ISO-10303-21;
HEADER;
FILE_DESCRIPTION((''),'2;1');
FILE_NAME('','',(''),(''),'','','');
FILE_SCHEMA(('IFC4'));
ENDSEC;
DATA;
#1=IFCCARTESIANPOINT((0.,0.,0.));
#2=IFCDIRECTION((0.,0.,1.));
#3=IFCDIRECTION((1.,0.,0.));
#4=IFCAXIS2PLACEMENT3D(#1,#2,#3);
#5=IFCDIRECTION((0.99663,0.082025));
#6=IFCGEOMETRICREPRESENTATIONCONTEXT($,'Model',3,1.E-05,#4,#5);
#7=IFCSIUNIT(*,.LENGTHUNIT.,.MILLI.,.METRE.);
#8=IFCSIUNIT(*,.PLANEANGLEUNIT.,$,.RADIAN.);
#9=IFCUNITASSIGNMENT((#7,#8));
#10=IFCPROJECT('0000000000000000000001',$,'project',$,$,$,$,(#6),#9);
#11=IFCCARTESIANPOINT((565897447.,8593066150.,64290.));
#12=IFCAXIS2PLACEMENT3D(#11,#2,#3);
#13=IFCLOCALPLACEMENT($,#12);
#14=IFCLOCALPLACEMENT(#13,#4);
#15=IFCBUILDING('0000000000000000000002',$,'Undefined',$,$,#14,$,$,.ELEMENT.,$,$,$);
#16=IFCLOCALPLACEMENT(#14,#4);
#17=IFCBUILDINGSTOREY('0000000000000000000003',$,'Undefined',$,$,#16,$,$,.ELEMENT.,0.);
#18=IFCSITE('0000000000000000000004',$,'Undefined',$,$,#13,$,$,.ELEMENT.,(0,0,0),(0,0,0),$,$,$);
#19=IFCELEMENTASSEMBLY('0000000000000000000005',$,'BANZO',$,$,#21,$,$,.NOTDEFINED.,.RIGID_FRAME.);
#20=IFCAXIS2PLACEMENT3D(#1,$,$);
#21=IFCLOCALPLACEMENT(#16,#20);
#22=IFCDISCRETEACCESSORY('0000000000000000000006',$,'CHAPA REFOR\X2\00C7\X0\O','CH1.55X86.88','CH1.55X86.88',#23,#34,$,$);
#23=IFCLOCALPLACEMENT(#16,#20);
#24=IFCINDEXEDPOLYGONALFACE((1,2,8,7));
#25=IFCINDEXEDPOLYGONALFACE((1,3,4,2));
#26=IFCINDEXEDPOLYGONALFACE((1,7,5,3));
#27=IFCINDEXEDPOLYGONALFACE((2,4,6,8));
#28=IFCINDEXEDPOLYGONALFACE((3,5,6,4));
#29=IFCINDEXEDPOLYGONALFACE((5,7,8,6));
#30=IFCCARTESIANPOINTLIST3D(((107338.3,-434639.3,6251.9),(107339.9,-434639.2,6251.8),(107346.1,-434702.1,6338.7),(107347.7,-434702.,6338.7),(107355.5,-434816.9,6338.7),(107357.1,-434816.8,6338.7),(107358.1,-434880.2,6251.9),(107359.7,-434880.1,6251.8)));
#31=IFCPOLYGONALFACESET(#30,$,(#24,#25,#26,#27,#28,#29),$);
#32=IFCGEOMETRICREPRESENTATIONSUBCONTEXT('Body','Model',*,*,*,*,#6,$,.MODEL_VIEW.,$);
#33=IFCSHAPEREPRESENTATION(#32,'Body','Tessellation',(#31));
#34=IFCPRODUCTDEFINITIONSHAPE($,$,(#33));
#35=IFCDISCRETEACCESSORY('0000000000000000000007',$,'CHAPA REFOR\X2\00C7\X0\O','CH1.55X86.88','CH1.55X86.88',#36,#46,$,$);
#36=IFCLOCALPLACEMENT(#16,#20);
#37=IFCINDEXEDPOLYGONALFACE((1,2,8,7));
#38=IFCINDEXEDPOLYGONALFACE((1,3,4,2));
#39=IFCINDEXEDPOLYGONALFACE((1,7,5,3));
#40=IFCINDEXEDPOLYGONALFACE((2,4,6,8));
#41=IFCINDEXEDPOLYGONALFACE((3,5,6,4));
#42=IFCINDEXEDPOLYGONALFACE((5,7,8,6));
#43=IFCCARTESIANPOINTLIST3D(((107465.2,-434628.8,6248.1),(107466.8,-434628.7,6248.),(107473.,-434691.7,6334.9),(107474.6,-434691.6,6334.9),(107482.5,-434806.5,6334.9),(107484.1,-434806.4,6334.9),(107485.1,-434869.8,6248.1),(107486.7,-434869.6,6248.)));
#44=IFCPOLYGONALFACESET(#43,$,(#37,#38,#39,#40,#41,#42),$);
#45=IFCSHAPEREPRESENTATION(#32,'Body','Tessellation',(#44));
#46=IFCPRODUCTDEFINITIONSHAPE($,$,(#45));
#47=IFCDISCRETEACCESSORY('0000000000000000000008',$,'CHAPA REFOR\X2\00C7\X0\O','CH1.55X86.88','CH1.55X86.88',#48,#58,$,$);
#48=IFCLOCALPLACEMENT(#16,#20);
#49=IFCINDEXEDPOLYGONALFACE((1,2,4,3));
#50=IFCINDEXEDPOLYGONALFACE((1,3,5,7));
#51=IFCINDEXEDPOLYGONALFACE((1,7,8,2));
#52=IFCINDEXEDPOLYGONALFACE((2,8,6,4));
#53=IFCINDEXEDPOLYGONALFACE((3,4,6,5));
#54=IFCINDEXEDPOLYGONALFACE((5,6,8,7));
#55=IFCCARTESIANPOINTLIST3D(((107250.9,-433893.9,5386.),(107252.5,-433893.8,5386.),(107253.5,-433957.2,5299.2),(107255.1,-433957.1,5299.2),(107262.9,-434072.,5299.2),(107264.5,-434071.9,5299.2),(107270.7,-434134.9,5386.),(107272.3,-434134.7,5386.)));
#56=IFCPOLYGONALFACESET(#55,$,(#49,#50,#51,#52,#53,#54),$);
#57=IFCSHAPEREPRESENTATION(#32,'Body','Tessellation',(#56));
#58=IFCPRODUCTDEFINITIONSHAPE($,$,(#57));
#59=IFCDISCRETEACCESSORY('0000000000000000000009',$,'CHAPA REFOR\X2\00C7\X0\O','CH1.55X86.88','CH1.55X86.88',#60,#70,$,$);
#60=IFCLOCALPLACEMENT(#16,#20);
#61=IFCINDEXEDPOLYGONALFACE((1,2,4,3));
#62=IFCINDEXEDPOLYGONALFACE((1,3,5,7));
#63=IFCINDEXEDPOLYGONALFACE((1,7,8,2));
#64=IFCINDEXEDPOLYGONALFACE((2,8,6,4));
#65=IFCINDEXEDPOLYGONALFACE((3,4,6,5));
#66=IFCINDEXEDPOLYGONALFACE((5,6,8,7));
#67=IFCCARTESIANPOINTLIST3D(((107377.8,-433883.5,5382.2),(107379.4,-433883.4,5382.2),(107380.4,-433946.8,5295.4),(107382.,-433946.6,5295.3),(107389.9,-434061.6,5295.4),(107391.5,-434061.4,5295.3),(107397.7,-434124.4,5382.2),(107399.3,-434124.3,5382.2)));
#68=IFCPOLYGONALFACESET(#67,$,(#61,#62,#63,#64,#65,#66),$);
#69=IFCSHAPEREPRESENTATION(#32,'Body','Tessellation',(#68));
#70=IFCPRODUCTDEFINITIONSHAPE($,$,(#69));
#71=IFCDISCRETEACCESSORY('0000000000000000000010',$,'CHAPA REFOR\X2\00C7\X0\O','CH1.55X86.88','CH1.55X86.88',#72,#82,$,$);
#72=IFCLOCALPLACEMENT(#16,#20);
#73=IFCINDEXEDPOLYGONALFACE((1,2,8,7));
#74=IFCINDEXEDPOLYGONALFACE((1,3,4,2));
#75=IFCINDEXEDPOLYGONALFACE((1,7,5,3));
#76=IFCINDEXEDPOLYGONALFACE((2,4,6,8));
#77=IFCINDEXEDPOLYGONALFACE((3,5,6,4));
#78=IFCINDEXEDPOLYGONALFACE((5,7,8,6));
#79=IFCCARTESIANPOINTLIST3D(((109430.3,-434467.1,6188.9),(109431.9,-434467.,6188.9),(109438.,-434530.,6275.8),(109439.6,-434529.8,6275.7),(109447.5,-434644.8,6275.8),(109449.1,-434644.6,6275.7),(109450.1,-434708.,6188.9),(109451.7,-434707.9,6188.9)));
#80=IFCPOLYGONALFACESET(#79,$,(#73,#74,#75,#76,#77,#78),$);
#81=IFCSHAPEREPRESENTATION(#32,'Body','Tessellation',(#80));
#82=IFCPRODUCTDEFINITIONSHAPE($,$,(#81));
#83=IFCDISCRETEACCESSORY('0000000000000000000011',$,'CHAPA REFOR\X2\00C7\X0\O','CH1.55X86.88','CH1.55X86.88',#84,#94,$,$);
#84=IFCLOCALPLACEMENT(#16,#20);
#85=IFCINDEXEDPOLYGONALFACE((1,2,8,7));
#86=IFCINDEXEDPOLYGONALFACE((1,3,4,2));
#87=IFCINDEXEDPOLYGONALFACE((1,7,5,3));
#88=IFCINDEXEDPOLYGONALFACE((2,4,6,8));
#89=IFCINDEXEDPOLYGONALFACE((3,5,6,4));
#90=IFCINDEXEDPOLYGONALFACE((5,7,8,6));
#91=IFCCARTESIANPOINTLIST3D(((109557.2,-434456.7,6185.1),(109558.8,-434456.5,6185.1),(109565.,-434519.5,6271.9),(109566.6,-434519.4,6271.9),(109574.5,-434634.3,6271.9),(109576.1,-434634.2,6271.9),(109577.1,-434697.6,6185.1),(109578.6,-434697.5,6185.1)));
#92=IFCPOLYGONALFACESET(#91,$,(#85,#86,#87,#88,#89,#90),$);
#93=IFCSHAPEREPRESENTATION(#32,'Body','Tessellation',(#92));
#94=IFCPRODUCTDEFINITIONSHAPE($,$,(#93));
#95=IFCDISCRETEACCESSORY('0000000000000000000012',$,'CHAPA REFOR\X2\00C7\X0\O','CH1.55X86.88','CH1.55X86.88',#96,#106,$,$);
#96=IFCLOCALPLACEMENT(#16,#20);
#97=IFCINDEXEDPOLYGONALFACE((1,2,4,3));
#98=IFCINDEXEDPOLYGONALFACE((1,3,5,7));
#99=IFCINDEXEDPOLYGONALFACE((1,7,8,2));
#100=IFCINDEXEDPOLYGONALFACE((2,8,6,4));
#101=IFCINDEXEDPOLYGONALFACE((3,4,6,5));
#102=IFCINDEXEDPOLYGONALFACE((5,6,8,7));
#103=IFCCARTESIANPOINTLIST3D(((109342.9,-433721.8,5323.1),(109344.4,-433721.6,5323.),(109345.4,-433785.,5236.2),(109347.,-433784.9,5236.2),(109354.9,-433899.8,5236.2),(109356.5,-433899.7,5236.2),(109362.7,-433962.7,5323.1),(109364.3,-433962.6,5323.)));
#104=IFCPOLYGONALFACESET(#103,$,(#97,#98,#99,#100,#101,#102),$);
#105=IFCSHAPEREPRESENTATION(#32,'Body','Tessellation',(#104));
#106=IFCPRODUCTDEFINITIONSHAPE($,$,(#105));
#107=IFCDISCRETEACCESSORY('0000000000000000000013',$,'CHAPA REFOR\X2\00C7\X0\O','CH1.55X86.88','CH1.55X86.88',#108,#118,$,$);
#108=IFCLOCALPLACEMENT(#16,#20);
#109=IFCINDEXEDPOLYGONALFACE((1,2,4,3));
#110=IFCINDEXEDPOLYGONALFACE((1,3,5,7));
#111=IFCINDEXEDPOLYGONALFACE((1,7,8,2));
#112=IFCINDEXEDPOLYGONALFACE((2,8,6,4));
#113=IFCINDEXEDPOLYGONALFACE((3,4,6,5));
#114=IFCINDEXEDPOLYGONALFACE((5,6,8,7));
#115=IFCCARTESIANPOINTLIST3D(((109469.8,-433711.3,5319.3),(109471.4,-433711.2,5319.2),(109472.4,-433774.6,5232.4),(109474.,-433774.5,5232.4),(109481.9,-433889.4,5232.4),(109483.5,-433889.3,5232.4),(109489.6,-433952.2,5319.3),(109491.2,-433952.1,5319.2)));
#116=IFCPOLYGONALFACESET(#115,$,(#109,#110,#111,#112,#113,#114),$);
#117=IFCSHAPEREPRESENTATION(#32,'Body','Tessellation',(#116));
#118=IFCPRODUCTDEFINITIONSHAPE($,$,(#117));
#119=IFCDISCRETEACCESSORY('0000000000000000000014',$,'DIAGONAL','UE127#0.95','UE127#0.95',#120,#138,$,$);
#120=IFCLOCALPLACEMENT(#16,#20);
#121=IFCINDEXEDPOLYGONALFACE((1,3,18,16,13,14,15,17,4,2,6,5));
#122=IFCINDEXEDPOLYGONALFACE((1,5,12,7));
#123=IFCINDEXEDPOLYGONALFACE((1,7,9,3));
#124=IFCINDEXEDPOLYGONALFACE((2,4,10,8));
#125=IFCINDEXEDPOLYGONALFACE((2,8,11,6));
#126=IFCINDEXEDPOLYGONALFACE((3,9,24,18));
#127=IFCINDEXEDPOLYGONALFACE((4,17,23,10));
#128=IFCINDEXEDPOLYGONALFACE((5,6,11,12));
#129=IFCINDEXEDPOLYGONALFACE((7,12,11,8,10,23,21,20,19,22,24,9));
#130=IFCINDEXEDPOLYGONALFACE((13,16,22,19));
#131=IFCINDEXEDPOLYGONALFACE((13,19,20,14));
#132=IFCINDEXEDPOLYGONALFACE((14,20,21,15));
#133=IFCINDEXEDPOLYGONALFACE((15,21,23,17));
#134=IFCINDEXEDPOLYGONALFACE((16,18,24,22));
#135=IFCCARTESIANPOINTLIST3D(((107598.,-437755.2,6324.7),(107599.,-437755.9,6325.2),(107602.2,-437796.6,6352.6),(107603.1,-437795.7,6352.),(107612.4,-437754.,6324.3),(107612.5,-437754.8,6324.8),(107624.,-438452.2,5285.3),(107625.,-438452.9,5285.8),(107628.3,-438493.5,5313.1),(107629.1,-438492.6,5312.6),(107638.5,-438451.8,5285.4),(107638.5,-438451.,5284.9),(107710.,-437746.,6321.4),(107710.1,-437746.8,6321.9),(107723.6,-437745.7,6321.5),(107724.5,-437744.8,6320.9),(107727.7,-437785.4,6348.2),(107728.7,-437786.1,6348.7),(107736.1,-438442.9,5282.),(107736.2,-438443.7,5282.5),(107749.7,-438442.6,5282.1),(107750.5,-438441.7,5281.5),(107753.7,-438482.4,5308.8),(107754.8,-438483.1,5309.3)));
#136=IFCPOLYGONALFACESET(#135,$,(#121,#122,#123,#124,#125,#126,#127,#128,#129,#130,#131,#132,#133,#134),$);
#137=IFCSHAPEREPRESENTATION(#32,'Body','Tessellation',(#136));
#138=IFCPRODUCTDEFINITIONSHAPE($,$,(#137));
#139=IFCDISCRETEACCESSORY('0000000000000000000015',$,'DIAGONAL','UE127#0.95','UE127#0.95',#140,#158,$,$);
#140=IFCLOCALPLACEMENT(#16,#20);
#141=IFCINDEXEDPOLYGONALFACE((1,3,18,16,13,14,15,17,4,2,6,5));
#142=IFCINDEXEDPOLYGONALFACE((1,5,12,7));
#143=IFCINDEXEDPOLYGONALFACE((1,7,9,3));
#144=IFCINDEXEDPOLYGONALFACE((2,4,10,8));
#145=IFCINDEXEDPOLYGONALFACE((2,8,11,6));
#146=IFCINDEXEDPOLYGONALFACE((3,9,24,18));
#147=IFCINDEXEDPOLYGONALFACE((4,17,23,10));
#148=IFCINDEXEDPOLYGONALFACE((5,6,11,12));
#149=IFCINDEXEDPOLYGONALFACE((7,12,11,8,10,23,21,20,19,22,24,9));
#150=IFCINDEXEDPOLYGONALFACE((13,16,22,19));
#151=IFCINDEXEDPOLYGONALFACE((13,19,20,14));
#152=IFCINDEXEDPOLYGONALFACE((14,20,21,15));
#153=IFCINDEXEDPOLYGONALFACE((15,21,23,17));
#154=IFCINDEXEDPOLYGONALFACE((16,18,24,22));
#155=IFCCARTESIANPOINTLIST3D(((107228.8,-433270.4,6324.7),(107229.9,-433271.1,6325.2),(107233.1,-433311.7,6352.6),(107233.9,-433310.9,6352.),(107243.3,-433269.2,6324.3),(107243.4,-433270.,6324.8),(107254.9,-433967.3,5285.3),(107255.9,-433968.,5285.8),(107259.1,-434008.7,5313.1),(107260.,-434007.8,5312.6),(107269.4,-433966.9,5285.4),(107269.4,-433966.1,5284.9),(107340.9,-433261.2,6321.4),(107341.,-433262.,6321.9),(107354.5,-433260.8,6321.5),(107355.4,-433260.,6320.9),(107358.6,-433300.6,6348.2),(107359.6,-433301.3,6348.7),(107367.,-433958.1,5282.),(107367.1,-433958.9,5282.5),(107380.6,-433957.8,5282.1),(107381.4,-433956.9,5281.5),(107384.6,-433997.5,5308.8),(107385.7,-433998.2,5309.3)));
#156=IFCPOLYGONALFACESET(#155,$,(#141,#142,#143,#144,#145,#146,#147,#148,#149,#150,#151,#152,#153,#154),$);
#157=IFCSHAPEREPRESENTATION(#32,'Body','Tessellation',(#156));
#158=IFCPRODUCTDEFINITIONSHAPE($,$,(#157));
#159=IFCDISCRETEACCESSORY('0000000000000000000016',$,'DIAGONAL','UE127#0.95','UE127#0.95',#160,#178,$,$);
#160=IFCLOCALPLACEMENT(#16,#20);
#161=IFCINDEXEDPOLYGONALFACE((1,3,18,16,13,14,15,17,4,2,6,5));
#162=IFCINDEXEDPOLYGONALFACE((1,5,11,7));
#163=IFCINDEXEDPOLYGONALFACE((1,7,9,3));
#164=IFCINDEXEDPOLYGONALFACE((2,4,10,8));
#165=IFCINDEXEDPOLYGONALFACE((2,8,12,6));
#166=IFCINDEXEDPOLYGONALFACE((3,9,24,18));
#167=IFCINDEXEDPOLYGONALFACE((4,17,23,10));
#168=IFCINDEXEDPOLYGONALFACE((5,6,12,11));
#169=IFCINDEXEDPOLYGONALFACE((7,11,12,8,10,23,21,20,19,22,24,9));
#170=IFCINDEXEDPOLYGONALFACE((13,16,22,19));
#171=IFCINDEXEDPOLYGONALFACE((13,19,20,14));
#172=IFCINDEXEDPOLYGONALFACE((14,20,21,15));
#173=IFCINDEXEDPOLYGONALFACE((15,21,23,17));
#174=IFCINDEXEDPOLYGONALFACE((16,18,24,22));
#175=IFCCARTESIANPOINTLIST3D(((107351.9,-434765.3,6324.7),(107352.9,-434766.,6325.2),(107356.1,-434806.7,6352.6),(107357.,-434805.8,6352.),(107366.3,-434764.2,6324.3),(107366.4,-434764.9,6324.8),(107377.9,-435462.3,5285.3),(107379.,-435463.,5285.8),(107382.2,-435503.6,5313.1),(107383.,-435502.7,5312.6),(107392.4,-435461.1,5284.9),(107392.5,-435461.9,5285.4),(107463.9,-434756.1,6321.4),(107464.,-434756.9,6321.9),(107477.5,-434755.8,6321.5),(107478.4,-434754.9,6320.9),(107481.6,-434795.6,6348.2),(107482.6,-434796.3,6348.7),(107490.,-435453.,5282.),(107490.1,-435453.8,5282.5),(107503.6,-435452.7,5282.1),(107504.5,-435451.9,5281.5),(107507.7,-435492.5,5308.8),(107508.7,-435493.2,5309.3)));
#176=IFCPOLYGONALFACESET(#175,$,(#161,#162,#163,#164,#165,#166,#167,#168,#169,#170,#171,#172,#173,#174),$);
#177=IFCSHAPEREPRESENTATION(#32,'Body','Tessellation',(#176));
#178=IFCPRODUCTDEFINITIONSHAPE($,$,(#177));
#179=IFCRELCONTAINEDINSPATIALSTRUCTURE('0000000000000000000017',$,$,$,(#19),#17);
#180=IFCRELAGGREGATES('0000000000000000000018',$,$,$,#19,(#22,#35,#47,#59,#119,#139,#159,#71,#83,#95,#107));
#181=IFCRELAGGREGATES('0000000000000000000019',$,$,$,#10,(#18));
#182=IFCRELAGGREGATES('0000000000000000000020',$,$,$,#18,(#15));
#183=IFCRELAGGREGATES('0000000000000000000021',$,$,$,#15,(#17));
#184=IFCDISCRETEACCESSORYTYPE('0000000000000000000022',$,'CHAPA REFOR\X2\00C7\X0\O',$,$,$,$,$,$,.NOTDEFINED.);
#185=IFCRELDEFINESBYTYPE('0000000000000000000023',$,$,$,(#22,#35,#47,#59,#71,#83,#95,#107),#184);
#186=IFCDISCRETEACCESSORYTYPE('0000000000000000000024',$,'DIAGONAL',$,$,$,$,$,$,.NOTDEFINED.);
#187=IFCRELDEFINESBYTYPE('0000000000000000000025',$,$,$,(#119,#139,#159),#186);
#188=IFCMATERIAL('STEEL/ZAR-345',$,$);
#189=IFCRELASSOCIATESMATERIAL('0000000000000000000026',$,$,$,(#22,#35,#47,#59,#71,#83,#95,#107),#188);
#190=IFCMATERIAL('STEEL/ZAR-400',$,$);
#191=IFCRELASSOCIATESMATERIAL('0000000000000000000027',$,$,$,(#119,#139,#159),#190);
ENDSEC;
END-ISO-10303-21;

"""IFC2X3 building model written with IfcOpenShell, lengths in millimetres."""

from ifc_helpers import new_model, si_unit, direction, frame, frame_2d, origin_with_axes, place, context, subcontext, project, spatial, polyline, c_section, outline, extrude, material, type_object, element, aggregate, save


model = new_model("IFC2X3")

# Units and contexts
model_context = context("Model", 3, precision=1e-05, world=origin_with_axes(), true_north=direction((0.99663, 0.082025)))
body_context = subcontext(model_context, "Body", "Model", "MODEL_VIEW")
ifc_project = project(units=[si_unit("LENGTHUNIT", "METRE", prefix="MILLI"), si_unit("PLANEANGLEUNIT", "RADIAN")], contexts=[model_context])

# Site, building, storey
site_placement = place(None, frame((565897447.0, 8593066150.0, 64290.0), z_axis=(0.0, 0.0, 1.0), x_axis=(1.0, 0.0, 0.0)))
site = spatial("IfcSite", under=ifc_project, at=site_placement, Name="Undefined", CompositionType="ELEMENT", RefLatitude=(0, 0, 0), RefLongitude=(0, 0, 0))
building_placement = place(site_placement, origin_with_axes())
building = spatial("IfcBuilding", under=site, at=building_placement, Name="Undefined", CompositionType="ELEMENT")
storey_placement = place(building_placement, origin_with_axes())
storey = spatial("IfcBuildingStorey", under=building, at=storey_placement, Name="Undefined", CompositionType="ELEMENT", Elevation=0.0)

# Element assembly, discrete accessories
assembly_placement = place(storey_placement, origin_with_axes())
assembly = element("IfcElementAssembly", 1, at=assembly_placement, inside=storey, Name="BANZO", AssemblyPlace="NOTDEFINED", PredefinedType="RIGID_FRAME")
ifc_material_1 = material(Name="STEEL/ZAR-345")
discrete_accessory_type_1 = type_object("IfcDiscreteAccessoryType", Name="CHAPA REFORÇO")
discrete_accessory_1_placement = place(assembly_placement, frame((107339.1, -434639.2, 6251.9), z_axis=(-0.996182, -0.081989, 0.029987), x_axis=(0.082025, -0.99663, 0.0)))
discrete_accessory_1 = element("IfcDiscreteAccessory", 2, at=discrete_accessory_1_placement, type_object=discrete_accessory_type_1, material=ifc_material_1, Name="CHAPA REFORÇO", Description="CH1.55X86.88", ObjectType="CH1.55X86.88", context=body_context, shape_type="SweptSolid", body=[
    extrude(outline(polyline([(0.0, 0.0), (241.7, 0.0), (178.5, 86.9), (63.3, 86.9), (0.0, 0.0)])), frame((0.0, 0.0, -0.8), z_axis=(0.0, 0.0, 1.0), x_axis=(1.0, 0.0, 0.0)), (0.0, 0.0, 1.0), 1.6),
])
discrete_accessory_2_placement = place(assembly_placement, frame((107466.0, -434628.8, 6248.0), z_axis=(-0.996182, -0.081989, 0.029987), x_axis=(0.082025, -0.99663, 0.0)))
discrete_accessory_2 = element("IfcDiscreteAccessory", 3, at=discrete_accessory_2_placement, type_object=discrete_accessory_type_1, material=ifc_material_1, Name="CHAPA REFORÇO", Description="CH1.55X86.88", ObjectType="CH1.55X86.88", context=body_context, shape_type="SweptSolid", body=[
    extrude(outline(polyline([(0.0, 0.0), (241.7, 0.0), (178.5, 86.9), (63.3, 86.9), (0.0, 0.0)])), frame((0.0, 0.0, -0.8), z_axis=(0.0, 0.0, 1.0), x_axis=(1.0, 0.0, 0.0)), (0.0, 0.0, 1.0), 1.6),
])
discrete_accessory_3_placement = place(assembly_placement, frame((107271.5, -434134.8, 5386.0), z_axis=(-0.996182, -0.081989, 0.029987), x_axis=(-0.082025, 0.99663, 0.0)))
discrete_accessory_3 = element("IfcDiscreteAccessory", 4, at=discrete_accessory_3_placement, type_object=discrete_accessory_type_1, material=ifc_material_1, Name="CHAPA REFORÇO", Description="CH1.55X86.88", ObjectType="CH1.55X86.88", context=body_context, shape_type="SweptSolid", body=[
    extrude(outline(polyline([(0.0, 0.0), (241.7, 0.0), (178.5, 86.9), (63.3, 86.9), (0.0, 0.0)])), frame((0.0, 0.0, -0.8), z_axis=(0.0, 0.0, 1.0), x_axis=(1.0, 0.0, 0.0)), (0.0, 0.0, 1.0), 1.6),
])
discrete_accessory_4_placement = place(assembly_placement, frame((107398.5, -434124.4, 5382.2), z_axis=(-0.996182, -0.081989, 0.029987), x_axis=(-0.082025, 0.99663, 0.0)))
discrete_accessory_4 = element("IfcDiscreteAccessory", 5, at=discrete_accessory_4_placement, type_object=discrete_accessory_type_1, material=ifc_material_1, Name="CHAPA REFORÇO", Description="CH1.55X86.88", ObjectType="CH1.55X86.88", context=body_context, shape_type="SweptSolid", body=[
    extrude(outline(polyline([(0.0, 0.0), (241.7, 0.0), (178.5, 86.9), (63.3, 86.9), (0.0, 0.0)])), frame((0.0, 0.0, -0.8), z_axis=(0.0, 0.0, 1.0), x_axis=(1.0, 0.0, 0.0)), (0.0, 0.0, 1.0), 1.6),
])
discrete_accessory_5_placement = place(assembly_placement, frame((109431.1, -434467.1, 6188.9), z_axis=(-0.996182, -0.081989, 0.029987), x_axis=(0.082025, -0.99663, 0.0)))
discrete_accessory_5 = element("IfcDiscreteAccessory", 6, at=discrete_accessory_5_placement, type_object=discrete_accessory_type_1, material=ifc_material_1, Name="CHAPA REFORÇO", Description="CH1.55X86.88", ObjectType="CH1.55X86.88", context=body_context, shape_type="SweptSolid", body=[
    extrude(outline(polyline([(0.0, 0.0), (241.7, 0.0), (178.5, 86.9), (63.3, 86.9), (0.0, 0.0)])), frame((0.0, 0.0, -0.8), z_axis=(0.0, 0.0, 1.0), x_axis=(1.0, 0.0, 0.0)), (0.0, 0.0, 1.0), 1.6),
])
discrete_accessory_6_placement = place(assembly_placement, frame((109558.0, -434456.6, 6185.1), z_axis=(-0.996182, -0.081989, 0.029987), x_axis=(0.082025, -0.99663, 0.0)))
discrete_accessory_6 = element("IfcDiscreteAccessory", 7, at=discrete_accessory_6_placement, type_object=discrete_accessory_type_1, material=ifc_material_1, Name="CHAPA REFORÇO", Description="CH1.55X86.88", ObjectType="CH1.55X86.88", context=body_context, shape_type="SweptSolid", body=[
    extrude(outline(polyline([(0.0, 0.0), (241.7, 0.0), (178.5, 86.9), (63.3, 86.9), (0.0, 0.0)])), frame((0.0, 0.0, -0.8), z_axis=(0.0, 0.0, 1.0), x_axis=(1.0, 0.0, 0.0)), (0.0, 0.0, 1.0), 1.6),
])
discrete_accessory_7_placement = place(assembly_placement, frame((109363.5, -433962.6, 5323.0), z_axis=(-0.996182, -0.081989, 0.029987), x_axis=(-0.082025, 0.99663, 0.0)))
discrete_accessory_7 = element("IfcDiscreteAccessory", 8, at=discrete_accessory_7_placement, type_object=discrete_accessory_type_1, material=ifc_material_1, Name="CHAPA REFORÇO", Description="CH1.55X86.88", ObjectType="CH1.55X86.88", context=body_context, shape_type="SweptSolid", body=[
    extrude(outline(polyline([(0.0, 0.0), (241.7, 0.0), (178.5, 86.9), (63.3, 86.9), (0.0, 0.0)])), frame((0.0, 0.0, -0.8), z_axis=(0.0, 0.0, 1.0), x_axis=(1.0, 0.0, 0.0)), (0.0, 0.0, 1.0), 1.6),
])
discrete_accessory_8_placement = place(assembly_placement, frame((109490.4, -433952.2, 5319.2), z_axis=(-0.996182, -0.081989, 0.029987), x_axis=(-0.082025, 0.99663, 0.0)))
discrete_accessory_8 = element("IfcDiscreteAccessory", 9, at=discrete_accessory_8_placement, type_object=discrete_accessory_type_1, material=ifc_material_1, Name="CHAPA REFORÇO", Description="CH1.55X86.88", ObjectType="CH1.55X86.88", context=body_context, shape_type="SweptSolid", body=[
    extrude(outline(polyline([(0.0, 0.0), (241.7, 0.0), (178.5, 86.9), (63.3, 86.9), (0.0, 0.0)])), frame((0.0, 0.0, -0.8), z_axis=(0.0, 0.0, 1.0), x_axis=(1.0, 0.0, 0.0)), (0.0, 0.0, 1.0), 1.6),
])
ifc_material_2 = material(Name="STEEL/ZAR-400")
discrete_accessory_type_2 = type_object("IfcDiscreteAccessoryType", Name="DIAGONAL")
discrete_accessory_9_placement = place(assembly_placement, frame((107689.4, -438467.6, 5297.3), z_axis=(0.996182, 0.081989, -0.029987), x_axis=(-0.020829, 0.556784, 0.830396)))
discrete_accessory_9 = element("IfcDiscreteAccessory", 10, at=discrete_accessory_9_placement, type_object=discrete_accessory_type_2, material=ifc_material_2, Name="DIAGONAL", Description="UE127#0.95", ObjectType="UE127#0.95", context=body_context, shape_type="SweptSolid", body=[
    extrude(c_section(Depth=127.0, Width=50.0, WallThickness=0.9, Girth=14.5, at=frame_2d((0.0, 0.0), x_axis=(1.0, 0.0))), frame((1251.7, 0.0, 0.0), z_axis=(-1.0, 0.0, 0.0), x_axis=(0.0, -1.0, 0.0)), (0.0, 0.0, 1.0), 1251.7),
])
discrete_accessory_10_placement = place(assembly_placement, frame((107320.3, -433982.8, 5297.3), z_axis=(0.996182, 0.081989, -0.029987), x_axis=(-0.020829, 0.556784, 0.830396)))
discrete_accessory_10 = element("IfcDiscreteAccessory", 11, at=discrete_accessory_10_placement, type_object=discrete_accessory_type_2, material=ifc_material_2, Name="DIAGONAL", Description="UE127#0.95", ObjectType="UE127#0.95", context=body_context, shape_type="SweptSolid", body=[
    extrude(c_section(Depth=127.0, Width=50.0, WallThickness=0.9, Girth=14.5, at=frame_2d((0.0, 0.0), x_axis=(1.0, 0.0))), frame((1251.7, 0.0, 0.0), z_axis=(-1.0, 0.0, 0.0), x_axis=(0.0, -1.0, 0.0)), (0.0, 0.0, 1.0), 1251.7),
])
discrete_accessory_11_placement = place(assembly_placement, frame((107443.3, -435477.7, 5297.3), z_axis=(0.996182, 0.081989, -0.029987), x_axis=(-0.020829, 0.556784, 0.830396)))
discrete_accessory_11 = element("IfcDiscreteAccessory", 12, at=discrete_accessory_11_placement, type_object=discrete_accessory_type_2, material=ifc_material_2, Name="DIAGONAL", Description="UE127#0.95", ObjectType="UE127#0.95", context=body_context, shape_type="SweptSolid", body=[
    extrude(c_section(Depth=127.0, Width=50.0, WallThickness=0.9, Girth=14.5, at=frame_2d((0.0, 0.0), x_axis=(1.0, 0.0))), frame((1251.7, 0.0, 0.0), z_axis=(-1.0, 0.0, 0.0), x_axis=(0.0, -1.0, 0.0)), (0.0, 0.0, 1.0), 1251.7),
])
aggregate(assembly, [discrete_accessory_1, discrete_accessory_2, discrete_accessory_3, discrete_accessory_4, discrete_accessory_9, discrete_accessory_10, discrete_accessory_11, discrete_accessory_5, discrete_accessory_6, discrete_accessory_7, discrete_accessory_8])

save(model, "model.ifc")
